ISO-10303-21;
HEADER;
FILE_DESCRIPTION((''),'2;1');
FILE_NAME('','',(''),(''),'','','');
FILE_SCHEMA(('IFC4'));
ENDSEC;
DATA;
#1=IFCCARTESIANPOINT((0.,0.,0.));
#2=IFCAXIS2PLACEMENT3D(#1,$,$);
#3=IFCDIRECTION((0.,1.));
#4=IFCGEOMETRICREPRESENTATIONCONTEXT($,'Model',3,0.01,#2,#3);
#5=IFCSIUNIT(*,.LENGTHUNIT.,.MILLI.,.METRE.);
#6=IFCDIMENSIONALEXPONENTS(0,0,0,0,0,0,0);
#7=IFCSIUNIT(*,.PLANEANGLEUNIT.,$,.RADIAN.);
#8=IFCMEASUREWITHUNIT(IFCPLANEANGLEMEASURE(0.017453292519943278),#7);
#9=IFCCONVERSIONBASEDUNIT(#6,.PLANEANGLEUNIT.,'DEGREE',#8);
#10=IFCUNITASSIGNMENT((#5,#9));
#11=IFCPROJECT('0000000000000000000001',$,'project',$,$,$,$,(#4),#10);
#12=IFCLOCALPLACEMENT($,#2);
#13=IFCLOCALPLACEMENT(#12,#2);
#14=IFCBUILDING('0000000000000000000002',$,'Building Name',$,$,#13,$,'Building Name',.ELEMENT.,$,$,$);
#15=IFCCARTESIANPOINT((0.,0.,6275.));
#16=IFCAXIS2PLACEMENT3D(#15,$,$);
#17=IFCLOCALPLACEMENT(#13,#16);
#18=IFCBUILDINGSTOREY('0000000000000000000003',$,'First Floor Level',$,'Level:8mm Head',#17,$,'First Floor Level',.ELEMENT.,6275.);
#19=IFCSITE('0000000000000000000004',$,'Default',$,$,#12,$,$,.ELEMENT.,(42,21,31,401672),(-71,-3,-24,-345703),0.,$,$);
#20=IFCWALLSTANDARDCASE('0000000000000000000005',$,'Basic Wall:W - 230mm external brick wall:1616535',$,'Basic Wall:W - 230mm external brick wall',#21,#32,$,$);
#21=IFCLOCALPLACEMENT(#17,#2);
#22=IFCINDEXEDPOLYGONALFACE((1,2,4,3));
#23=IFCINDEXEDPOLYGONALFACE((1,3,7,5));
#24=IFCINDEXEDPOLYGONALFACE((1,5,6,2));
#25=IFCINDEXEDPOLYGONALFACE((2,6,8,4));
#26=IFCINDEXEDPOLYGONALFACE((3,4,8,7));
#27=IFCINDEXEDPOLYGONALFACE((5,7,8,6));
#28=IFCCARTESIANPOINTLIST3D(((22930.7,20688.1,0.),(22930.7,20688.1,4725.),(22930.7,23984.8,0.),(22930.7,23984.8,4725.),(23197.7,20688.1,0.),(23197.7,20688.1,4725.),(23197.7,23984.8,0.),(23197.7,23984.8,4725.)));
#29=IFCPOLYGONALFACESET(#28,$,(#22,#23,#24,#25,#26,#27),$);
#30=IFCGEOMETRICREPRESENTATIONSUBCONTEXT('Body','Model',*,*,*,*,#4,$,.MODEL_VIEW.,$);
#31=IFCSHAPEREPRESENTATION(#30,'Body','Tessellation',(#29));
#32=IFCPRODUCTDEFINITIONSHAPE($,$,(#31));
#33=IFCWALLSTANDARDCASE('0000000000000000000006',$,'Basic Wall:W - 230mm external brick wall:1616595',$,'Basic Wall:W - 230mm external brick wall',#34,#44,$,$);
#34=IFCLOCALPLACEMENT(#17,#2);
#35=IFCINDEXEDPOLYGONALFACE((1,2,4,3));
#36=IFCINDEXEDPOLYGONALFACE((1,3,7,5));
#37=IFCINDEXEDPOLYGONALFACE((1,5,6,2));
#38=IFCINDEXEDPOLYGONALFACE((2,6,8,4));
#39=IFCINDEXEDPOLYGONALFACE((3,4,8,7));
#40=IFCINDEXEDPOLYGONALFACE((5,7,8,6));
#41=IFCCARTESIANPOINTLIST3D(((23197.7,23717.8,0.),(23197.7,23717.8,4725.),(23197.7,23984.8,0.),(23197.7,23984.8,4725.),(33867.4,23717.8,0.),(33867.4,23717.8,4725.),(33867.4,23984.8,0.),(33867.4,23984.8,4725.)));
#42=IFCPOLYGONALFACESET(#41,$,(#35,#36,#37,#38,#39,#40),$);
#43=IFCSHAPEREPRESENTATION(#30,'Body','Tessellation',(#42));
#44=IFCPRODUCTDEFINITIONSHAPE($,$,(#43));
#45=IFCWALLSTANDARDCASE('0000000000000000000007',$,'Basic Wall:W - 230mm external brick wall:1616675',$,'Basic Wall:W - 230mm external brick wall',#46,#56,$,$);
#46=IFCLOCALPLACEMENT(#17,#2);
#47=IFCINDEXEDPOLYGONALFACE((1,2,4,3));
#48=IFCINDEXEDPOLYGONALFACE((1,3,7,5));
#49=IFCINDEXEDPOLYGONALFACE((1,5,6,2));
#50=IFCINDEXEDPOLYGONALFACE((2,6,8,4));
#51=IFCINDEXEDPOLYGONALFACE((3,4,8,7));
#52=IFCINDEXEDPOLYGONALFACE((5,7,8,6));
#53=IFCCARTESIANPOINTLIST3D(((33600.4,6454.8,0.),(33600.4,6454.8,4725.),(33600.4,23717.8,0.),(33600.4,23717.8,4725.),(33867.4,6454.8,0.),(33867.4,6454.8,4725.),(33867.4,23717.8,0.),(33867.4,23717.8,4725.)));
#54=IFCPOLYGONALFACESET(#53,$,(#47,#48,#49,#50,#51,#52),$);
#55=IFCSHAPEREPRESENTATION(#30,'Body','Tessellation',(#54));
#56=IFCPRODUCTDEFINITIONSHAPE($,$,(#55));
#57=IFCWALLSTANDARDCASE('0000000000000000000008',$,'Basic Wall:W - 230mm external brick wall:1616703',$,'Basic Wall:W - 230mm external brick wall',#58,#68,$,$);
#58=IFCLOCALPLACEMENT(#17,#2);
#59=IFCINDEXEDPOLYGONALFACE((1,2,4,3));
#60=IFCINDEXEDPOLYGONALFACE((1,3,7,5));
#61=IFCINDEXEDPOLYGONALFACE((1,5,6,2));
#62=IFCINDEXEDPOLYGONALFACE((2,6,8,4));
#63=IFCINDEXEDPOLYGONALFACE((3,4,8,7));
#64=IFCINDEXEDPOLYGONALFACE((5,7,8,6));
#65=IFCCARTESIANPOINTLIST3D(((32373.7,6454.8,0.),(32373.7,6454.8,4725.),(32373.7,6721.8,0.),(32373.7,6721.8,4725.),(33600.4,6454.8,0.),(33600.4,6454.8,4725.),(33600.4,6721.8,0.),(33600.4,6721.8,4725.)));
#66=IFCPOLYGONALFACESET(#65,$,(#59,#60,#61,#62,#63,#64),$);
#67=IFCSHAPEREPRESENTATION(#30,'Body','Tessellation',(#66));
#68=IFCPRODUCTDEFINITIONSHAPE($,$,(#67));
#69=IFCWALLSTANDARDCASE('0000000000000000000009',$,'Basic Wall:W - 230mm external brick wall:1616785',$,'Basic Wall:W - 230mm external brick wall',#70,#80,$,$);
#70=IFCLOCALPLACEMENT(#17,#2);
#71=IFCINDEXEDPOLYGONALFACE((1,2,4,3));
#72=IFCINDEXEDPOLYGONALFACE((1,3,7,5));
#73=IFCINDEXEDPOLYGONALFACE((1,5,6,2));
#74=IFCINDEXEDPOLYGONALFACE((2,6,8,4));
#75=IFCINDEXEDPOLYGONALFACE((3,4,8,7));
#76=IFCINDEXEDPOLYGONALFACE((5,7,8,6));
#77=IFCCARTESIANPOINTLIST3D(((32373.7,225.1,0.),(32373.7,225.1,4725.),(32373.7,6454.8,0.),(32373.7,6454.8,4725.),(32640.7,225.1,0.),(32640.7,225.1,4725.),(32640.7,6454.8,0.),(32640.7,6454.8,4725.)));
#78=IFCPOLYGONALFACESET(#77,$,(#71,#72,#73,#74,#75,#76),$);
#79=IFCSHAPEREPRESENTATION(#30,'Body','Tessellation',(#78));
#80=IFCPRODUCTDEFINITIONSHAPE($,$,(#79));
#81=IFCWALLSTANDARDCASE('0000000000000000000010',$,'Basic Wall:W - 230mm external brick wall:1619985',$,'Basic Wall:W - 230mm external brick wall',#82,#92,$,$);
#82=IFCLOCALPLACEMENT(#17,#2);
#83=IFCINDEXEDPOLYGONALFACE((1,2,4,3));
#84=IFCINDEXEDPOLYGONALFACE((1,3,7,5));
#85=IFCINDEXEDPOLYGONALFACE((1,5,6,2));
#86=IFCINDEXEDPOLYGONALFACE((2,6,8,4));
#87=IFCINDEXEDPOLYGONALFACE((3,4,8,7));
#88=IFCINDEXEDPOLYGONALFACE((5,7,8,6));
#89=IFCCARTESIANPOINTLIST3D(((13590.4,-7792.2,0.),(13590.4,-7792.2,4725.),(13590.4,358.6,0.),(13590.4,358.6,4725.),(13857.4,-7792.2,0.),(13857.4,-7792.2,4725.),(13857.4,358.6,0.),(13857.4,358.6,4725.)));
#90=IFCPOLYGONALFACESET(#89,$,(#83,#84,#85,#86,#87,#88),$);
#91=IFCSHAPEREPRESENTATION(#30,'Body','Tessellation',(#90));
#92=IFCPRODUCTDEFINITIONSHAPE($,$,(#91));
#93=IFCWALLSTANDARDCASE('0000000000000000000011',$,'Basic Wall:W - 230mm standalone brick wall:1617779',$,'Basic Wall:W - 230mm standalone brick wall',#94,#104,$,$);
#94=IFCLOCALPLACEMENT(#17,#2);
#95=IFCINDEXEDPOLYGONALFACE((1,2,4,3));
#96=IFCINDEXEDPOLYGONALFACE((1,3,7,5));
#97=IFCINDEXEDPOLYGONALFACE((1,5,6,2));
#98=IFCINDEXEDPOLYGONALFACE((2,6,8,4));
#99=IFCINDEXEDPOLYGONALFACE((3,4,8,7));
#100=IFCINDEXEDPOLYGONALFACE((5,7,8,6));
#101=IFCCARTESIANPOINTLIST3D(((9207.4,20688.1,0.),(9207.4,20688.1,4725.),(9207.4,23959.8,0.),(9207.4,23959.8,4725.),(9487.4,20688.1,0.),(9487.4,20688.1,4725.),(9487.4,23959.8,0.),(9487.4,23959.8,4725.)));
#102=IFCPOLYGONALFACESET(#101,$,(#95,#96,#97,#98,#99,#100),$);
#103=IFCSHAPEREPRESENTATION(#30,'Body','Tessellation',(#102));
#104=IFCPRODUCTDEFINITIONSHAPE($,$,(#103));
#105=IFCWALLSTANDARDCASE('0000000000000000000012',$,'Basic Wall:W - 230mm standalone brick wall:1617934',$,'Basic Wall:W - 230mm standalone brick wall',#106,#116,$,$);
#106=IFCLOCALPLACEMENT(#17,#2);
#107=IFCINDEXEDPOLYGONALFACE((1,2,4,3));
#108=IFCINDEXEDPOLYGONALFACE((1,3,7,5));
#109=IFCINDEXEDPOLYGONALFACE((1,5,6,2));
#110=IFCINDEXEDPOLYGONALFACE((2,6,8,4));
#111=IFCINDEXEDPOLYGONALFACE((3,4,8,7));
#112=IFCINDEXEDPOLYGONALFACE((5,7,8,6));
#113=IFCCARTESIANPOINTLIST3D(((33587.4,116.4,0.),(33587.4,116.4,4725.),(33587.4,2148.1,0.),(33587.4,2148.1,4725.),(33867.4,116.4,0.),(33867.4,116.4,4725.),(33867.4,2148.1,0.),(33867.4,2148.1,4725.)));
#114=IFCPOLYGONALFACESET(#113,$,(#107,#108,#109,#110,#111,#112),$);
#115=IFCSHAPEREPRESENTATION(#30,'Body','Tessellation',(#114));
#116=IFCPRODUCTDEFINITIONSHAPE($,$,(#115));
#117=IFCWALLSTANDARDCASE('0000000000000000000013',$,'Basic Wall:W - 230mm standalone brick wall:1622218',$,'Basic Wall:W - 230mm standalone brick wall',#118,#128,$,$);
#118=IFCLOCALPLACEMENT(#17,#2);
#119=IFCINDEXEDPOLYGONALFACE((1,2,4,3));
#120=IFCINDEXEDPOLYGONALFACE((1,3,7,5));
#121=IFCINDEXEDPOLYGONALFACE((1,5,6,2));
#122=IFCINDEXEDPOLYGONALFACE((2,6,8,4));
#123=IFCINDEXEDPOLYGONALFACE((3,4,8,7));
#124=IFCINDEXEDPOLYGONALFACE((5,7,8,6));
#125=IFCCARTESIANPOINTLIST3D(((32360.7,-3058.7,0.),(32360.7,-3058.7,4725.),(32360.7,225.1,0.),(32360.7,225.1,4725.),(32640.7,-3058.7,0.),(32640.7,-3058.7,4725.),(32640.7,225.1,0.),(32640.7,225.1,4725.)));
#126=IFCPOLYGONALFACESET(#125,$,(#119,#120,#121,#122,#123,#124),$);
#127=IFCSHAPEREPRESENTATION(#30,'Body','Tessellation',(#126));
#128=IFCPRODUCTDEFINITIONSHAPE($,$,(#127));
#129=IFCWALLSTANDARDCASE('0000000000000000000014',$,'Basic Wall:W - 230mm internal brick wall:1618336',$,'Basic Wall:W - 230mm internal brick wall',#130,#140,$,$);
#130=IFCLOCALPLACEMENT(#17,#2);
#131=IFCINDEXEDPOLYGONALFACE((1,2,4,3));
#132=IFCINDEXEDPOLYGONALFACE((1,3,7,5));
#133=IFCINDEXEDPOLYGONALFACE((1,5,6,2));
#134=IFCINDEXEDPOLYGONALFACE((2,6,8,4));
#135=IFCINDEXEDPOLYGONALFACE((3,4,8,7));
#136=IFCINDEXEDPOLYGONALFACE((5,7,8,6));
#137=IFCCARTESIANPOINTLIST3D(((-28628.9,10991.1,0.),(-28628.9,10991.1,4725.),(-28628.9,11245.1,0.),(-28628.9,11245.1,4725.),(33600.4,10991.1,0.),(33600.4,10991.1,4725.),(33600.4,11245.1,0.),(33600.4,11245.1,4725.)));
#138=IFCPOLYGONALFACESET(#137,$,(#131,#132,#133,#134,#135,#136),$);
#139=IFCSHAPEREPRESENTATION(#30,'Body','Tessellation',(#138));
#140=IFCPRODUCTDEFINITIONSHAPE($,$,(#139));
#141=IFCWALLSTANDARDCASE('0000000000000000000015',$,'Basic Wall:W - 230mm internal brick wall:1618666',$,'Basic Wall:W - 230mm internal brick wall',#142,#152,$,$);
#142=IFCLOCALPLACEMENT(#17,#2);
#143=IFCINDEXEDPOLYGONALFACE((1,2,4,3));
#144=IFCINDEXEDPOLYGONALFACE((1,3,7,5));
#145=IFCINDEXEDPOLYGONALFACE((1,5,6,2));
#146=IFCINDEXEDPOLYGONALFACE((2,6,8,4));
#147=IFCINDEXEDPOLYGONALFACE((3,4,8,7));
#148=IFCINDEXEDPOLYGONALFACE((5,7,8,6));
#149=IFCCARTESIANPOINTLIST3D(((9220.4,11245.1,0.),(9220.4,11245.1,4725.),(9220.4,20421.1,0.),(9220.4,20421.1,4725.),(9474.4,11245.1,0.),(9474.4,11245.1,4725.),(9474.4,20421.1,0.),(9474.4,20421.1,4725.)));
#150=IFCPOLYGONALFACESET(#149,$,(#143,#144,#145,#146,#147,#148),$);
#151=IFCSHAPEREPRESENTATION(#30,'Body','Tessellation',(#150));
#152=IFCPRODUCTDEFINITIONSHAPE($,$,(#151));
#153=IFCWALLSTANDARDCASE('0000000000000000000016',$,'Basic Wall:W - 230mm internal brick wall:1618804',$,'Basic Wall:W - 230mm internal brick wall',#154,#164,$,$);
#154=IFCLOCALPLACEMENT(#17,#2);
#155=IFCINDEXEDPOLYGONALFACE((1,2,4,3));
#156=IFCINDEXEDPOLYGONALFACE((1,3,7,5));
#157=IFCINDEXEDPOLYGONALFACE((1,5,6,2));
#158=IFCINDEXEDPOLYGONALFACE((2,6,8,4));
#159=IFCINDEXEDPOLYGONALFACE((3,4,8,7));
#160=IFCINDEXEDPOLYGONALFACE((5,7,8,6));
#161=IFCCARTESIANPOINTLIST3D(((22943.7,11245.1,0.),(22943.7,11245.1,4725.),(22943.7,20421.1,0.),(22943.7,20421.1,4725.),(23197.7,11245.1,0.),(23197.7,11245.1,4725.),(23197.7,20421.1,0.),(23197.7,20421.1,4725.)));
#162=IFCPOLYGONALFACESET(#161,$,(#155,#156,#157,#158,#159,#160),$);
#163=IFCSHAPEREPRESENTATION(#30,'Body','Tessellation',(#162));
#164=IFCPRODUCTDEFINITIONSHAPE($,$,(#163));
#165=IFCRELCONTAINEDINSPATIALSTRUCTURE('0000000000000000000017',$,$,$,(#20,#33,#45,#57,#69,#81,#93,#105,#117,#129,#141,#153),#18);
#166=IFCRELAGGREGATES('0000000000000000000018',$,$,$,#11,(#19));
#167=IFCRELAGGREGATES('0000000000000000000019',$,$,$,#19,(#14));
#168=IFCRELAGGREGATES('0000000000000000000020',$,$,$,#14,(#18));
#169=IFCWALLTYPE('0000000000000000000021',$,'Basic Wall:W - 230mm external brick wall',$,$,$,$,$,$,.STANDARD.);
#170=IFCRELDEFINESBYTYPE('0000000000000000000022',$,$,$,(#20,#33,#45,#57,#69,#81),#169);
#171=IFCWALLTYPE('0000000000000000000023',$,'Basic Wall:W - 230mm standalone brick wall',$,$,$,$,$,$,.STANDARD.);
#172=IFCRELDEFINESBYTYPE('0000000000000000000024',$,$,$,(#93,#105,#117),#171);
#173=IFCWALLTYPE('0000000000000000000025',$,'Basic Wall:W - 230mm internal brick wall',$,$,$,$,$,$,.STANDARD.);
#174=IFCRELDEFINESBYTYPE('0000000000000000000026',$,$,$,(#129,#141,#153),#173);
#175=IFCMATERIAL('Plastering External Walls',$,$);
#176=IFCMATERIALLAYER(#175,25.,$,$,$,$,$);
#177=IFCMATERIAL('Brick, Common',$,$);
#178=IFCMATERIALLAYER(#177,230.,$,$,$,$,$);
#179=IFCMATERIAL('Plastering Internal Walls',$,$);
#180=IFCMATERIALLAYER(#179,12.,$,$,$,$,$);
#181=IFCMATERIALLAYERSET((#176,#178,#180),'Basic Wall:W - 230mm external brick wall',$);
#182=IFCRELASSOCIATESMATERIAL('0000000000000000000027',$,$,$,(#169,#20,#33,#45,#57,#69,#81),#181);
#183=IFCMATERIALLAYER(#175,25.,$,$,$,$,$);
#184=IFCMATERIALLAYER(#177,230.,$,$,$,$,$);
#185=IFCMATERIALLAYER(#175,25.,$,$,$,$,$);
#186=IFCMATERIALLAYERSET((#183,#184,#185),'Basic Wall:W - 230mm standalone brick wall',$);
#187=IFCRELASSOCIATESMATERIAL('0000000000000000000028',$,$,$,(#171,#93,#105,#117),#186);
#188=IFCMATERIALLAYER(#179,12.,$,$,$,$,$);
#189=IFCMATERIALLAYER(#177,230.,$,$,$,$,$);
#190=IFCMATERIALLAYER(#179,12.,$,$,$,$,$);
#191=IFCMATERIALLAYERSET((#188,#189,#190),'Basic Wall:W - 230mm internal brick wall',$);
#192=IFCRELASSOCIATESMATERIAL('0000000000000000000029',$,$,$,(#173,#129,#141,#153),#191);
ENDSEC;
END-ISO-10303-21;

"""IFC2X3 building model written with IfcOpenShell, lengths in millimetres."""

from ifc_helpers import new_model, entity, si_unit, converted_unit, direction, frame, frame_2d, origin, place, context, subcontext, project, spatial, rectangle, extrude, material, layer, layer_set, layer_usage, type_object, element, save


model = new_model("IFC2X3")

# Units and contexts
model_context = context("Model", 3, precision=0.01, world=origin(), true_north=direction((0.0, 1.0)))
body_context = subcontext(model_context, "Body", "Model", "MODEL_VIEW")
ifc_project = project(units=[si_unit("LENGTHUNIT", "METRE", prefix="MILLI"), converted_unit("PLANEANGLEUNIT", "DEGREE", entity("IfcPlaneAngleMeasure", 0.017453292519943278), si_unit("PLANEANGLEUNIT", "RADIAN"), dimensions=[0, 0, 0, 0, 0, 0, 0])], contexts=[model_context])

# Site, building, storey
site_placement = place(None, origin())
site = spatial("IfcSite", under=ifc_project, at=site_placement, Name="Default", CompositionType="ELEMENT", RefLatitude=(42, 21, 31, 401672), RefLongitude=(-71, -3, -24, -345703), RefElevation=0.0)
building_placement = place(site_placement, origin())
building = spatial("IfcBuilding", under=site, at=building_placement, Name="Building Name", LongName="Building Name", CompositionType="ELEMENT")
storey_placement = place(building_placement, frame((0.0, 0.0, 6275.0)))
storey = spatial("IfcBuildingStorey", under=building, at=storey_placement, Name="First Floor Level", ObjectType="Level:8mm Head", LongName="First Floor Level", CompositionType="ELEMENT", Elevation=6275.0)

# Walls
ifc_material_1 = material(Name="Plastering External Walls")
ifc_layer_1 = layer(ifc_material_1, 25.0)
ifc_material_2 = material(Name="Brick, Common")
ifc_layer_2 = layer(ifc_material_2, 230.0)
ifc_material_3 = material(Name="Plastering Internal Walls")
ifc_layer_3 = layer(ifc_material_3, 12.0)
ifc_layer_set_1 = layer_set([ifc_layer_1, ifc_layer_2, ifc_layer_3], Name="Basic Wall:W - 230mm external brick wall")
ifc_layer_usage_1 = layer_usage(ifc_layer_set_1, "AXIS2", "NEGATIVE", 133.5)
wall_type_1 = type_object("IfcWallType", Name="Basic Wall:W - 230mm external brick wall", PredefinedType="STANDARD", material=ifc_layer_set_1)
wall_1_placement = place(storey_placement, frame((23064.2, 20688.1, 0.0), z_axis=(0.0, 0.0, 1.0), x_axis=(0.0, 1.0, 0.0)))
element("IfcWallStandardCase", 1, at=wall_1_placement, inside=storey, type_object=wall_type_1, material=ifc_layer_usage_1, Name="Basic Wall:W - 230mm external brick wall:1616535", ObjectType="Basic Wall:W - 230mm external brick wall", context=body_context, shape_type="SweptSolid", body=[
    extrude(rectangle(XDim=3296.7, YDim=267.0, at=frame_2d((1648.3, 0.0), x_axis=(-1.0, 0.0))), origin(), (0.0, 0.0, 1.0), 4725.0),
])
ifc_layer_usage_2 = layer_usage(ifc_layer_set_1, "AXIS2", "NEGATIVE", 133.5)
wall_2_placement = place(storey_placement, frame((23197.7, 23851.3, 0.0)))
element("IfcWallStandardCase", 2, at=wall_2_placement, inside=storey, type_object=wall_type_1, material=ifc_layer_usage_2, Name="Basic Wall:W - 230mm external brick wall:1616595", ObjectType="Basic Wall:W - 230mm external brick wall", context=body_context, shape_type="SweptSolid", body=[
    extrude(rectangle(XDim=10669.7, YDim=267.0, at=frame_2d((5334.8, 0.0), x_axis=(-1.0, 0.0))), origin(), (0.0, 0.0, 1.0), 4725.0),
])
ifc_layer_usage_3 = layer_usage(ifc_layer_set_1, "AXIS2", "NEGATIVE", 133.5)
wall_3_placement = place(storey_placement, frame((33733.9, 23717.8, 0.0), z_axis=(0.0, 0.0, 1.0), x_axis=(0.0, -1.0, 0.0)))
element("IfcWallStandardCase", 3, at=wall_3_placement, inside=storey, type_object=wall_type_1, material=ifc_layer_usage_3, Name="Basic Wall:W - 230mm external brick wall:1616675", ObjectType="Basic Wall:W - 230mm external brick wall", context=body_context, shape_type="SweptSolid", body=[
    extrude(rectangle(XDim=17263.0, YDim=267.0, at=frame_2d((8631.5, 0.0), x_axis=(-1.0, 0.0))), origin(), (0.0, 0.0, 1.0), 4725.0),
])
ifc_layer_usage_4 = layer_usage(ifc_layer_set_1, "AXIS2", "NEGATIVE", 133.5)
wall_4_placement = place(storey_placement, frame((33600.4, 6588.3, 0.0), z_axis=(0.0, 0.0, 1.0), x_axis=(-1.0, 0.0, 0.0)))
element("IfcWallStandardCase", 4, at=wall_4_placement, inside=storey, type_object=wall_type_1, material=ifc_layer_usage_4, Name="Basic Wall:W - 230mm external brick wall:1616703", ObjectType="Basic Wall:W - 230mm external brick wall", context=body_context, shape_type="SweptSolid", body=[
    extrude(rectangle(XDim=1226.7, YDim=267.0, at=frame_2d((613.3, 0.0), x_axis=(-1.0, 0.0))), origin(), (0.0, 0.0, 1.0), 4725.0),
])
ifc_layer_usage_5 = layer_usage(ifc_layer_set_1, "AXIS2", "NEGATIVE", 133.5)
wall_5_placement = place(storey_placement, frame((32507.2, 6454.8, 0.0), z_axis=(0.0, 0.0, 1.0), x_axis=(0.0, -1.0, 0.0)))
element("IfcWallStandardCase", 5, at=wall_5_placement, inside=storey, type_object=wall_type_1, material=ifc_layer_usage_5, Name="Basic Wall:W - 230mm external brick wall:1616785", ObjectType="Basic Wall:W - 230mm external brick wall", context=body_context, shape_type="SweptSolid", body=[
    extrude(rectangle(XDim=6229.6, YDim=267.0, at=frame_2d((3114.8, 0.0), x_axis=(-1.0, 0.0))), origin(), (0.0, 0.0, 1.0), 4725.0),
])
ifc_layer_usage_6 = layer_usage(ifc_layer_set_1, "AXIS2", "NEGATIVE", 133.5)
wall_6_placement = place(storey_placement, frame((13723.9, 358.6, 0.0), z_axis=(0.0, 0.0, 1.0), x_axis=(0.0, -1.0, 0.0)))
element("IfcWallStandardCase", 6, at=wall_6_placement, inside=storey, type_object=wall_type_1, material=ifc_layer_usage_6, Name="Basic Wall:W - 230mm external brick wall:1619985", ObjectType="Basic Wall:W - 230mm external brick wall", context=body_context, shape_type="SweptSolid", body=[
    extrude(rectangle(XDim=8150.9, YDim=267.0, at=frame_2d((4075.4, 0.0), x_axis=(-1.0, 0.0))), origin(), (0.0, 0.0, 1.0), 4725.0),
])
ifc_layer_4 = layer(ifc_material_1, 25.0)
ifc_layer_5 = layer(ifc_material_2, 230.0)
ifc_layer_6 = layer(ifc_material_1, 25.0)
ifc_layer_set_2 = layer_set([ifc_layer_4, ifc_layer_5, ifc_layer_6], Name="Basic Wall:W - 230mm standalone brick wall")
ifc_layer_usage_7 = layer_usage(ifc_layer_set_2, "AXIS2", "NEGATIVE", 140.0)
wall_type_2 = type_object("IfcWallType", Name="Basic Wall:W - 230mm standalone brick wall", PredefinedType="STANDARD", material=ifc_layer_set_2)
wall_7_placement = place(storey_placement, frame((9347.4, 20688.1, 0.0), z_axis=(0.0, 0.0, 1.0), x_axis=(0.0, 1.0, 0.0)))
element("IfcWallStandardCase", 7, at=wall_7_placement, inside=storey, type_object=wall_type_2, material=ifc_layer_usage_7, Name="Basic Wall:W - 230mm standalone brick wall:1617779", ObjectType="Basic Wall:W - 230mm standalone brick wall", context=body_context, shape_type="SweptSolid", body=[
    extrude(rectangle(XDim=3271.7, YDim=280.0, at=frame_2d((1635.8, 0.0), x_axis=(-1.0, 0.0))), origin(), (0.0, 0.0, 1.0), 4725.0),
])
ifc_layer_usage_8 = layer_usage(ifc_layer_set_2, "AXIS2", "NEGATIVE", 140.0)
wall_8_placement = place(storey_placement, frame((33727.4, 116.4, 0.0), z_axis=(0.0, 0.0, 1.0), x_axis=(0.0, 1.0, 0.0)))
element("IfcWallStandardCase", 8, at=wall_8_placement, inside=storey, type_object=wall_type_2, material=ifc_layer_usage_8, Name="Basic Wall:W - 230mm standalone brick wall:1617934", ObjectType="Basic Wall:W - 230mm standalone brick wall", context=body_context, shape_type="SweptSolid", body=[
    extrude(rectangle(XDim=2031.7, YDim=280.0, at=frame_2d((1015.8, 0.0), x_axis=(-1.0, 0.0))), origin(), (0.0, 0.0, 1.0), 4725.0),
])
ifc_layer_usage_9 = layer_usage(ifc_layer_set_2, "AXIS2", "NEGATIVE", 140.0)
wall_9_placement = place(storey_placement, frame((32500.7, 225.1, 0.0), z_axis=(0.0, 0.0, 1.0), x_axis=(0.0, -1.0, 0.0)))
element("IfcWallStandardCase", 9, at=wall_9_placement, inside=storey, type_object=wall_type_2, material=ifc_layer_usage_9, Name="Basic Wall:W - 230mm standalone brick wall:1622218", ObjectType="Basic Wall:W - 230mm standalone brick wall", context=body_context, shape_type="SweptSolid", body=[
    extrude(rectangle(XDim=3283.9, YDim=280.0, at=frame_2d((1641.9, 0.0), x_axis=(-1.0, 0.0))), origin(), (0.0, 0.0, 1.0), 4725.0),
])
ifc_layer_7 = layer(ifc_material_3, 12.0)
ifc_layer_8 = layer(ifc_material_2, 230.0)
ifc_layer_9 = layer(ifc_material_3, 12.0)
ifc_layer_set_3 = layer_set([ifc_layer_7, ifc_layer_8, ifc_layer_9], Name="Basic Wall:W - 230mm internal brick wall")
ifc_layer_usage_10 = layer_usage(ifc_layer_set_3, "AXIS2", "NEGATIVE", 127.0)
wall_type_3 = type_object("IfcWallType", Name="Basic Wall:W - 230mm internal brick wall", PredefinedType="STANDARD", material=ifc_layer_set_3)
wall_10_placement = place(storey_placement, frame((33600.4, 11118.1, 0.0), z_axis=(0.0, 0.0, 1.0), x_axis=(-1.0, 0.0, 0.0)))
element("IfcWallStandardCase", 10, at=wall_10_placement, inside=storey, type_object=wall_type_3, material=ifc_layer_usage_10, Name="Basic Wall:W - 230mm internal brick wall:1618336", ObjectType="Basic Wall:W - 230mm internal brick wall", context=body_context, shape_type="SweptSolid", body=[
    extrude(rectangle(XDim=62229.3, YDim=254.0, at=frame_2d((31114.7, 0.0), x_axis=(-1.0, 0.0))), origin(), (0.0, 0.0, 1.0), 4725.0),
])
ifc_layer_usage_11 = layer_usage(ifc_layer_set_3, "AXIS2", "NEGATIVE", 127.0)
wall_11_placement = place(storey_placement, frame((9347.4, 11245.1, 0.0), z_axis=(0.0, 0.0, 1.0), x_axis=(0.0, 1.0, 0.0)))
element("IfcWallStandardCase", 11, at=wall_11_placement, inside=storey, type_object=wall_type_3, material=ifc_layer_usage_11, Name="Basic Wall:W - 230mm internal brick wall:1618666", ObjectType="Basic Wall:W - 230mm internal brick wall", context=body_context, shape_type="SweptSolid", body=[
    extrude(rectangle(XDim=9176.0, YDim=254.0, at=frame_2d((4588.0, 0.0), x_axis=(-1.0, 0.0))), origin(), (0.0, 0.0, 1.0), 4725.0),
])
ifc_layer_usage_12 = layer_usage(ifc_layer_set_3, "AXIS2", "NEGATIVE", 127.0)
wall_12_placement = place(storey_placement, frame((23070.7, 11245.1, 0.0), z_axis=(0.0, 0.0, 1.0), x_axis=(0.0, 1.0, 0.0)))
element("IfcWallStandardCase", 12, at=wall_12_placement, inside=storey, type_object=wall_type_3, material=ifc_layer_usage_12, Name="Basic Wall:W - 230mm internal brick wall:1618804", ObjectType="Basic Wall:W - 230mm internal brick wall", context=body_context, shape_type="SweptSolid", body=[
    extrude(rectangle(XDim=9176.0, YDim=254.0, at=frame_2d((4588.0, 0.0), x_axis=(-1.0, 0.0))), origin(), (0.0, 0.0, 1.0), 4725.0),
])

save(model, "model.ifc")
